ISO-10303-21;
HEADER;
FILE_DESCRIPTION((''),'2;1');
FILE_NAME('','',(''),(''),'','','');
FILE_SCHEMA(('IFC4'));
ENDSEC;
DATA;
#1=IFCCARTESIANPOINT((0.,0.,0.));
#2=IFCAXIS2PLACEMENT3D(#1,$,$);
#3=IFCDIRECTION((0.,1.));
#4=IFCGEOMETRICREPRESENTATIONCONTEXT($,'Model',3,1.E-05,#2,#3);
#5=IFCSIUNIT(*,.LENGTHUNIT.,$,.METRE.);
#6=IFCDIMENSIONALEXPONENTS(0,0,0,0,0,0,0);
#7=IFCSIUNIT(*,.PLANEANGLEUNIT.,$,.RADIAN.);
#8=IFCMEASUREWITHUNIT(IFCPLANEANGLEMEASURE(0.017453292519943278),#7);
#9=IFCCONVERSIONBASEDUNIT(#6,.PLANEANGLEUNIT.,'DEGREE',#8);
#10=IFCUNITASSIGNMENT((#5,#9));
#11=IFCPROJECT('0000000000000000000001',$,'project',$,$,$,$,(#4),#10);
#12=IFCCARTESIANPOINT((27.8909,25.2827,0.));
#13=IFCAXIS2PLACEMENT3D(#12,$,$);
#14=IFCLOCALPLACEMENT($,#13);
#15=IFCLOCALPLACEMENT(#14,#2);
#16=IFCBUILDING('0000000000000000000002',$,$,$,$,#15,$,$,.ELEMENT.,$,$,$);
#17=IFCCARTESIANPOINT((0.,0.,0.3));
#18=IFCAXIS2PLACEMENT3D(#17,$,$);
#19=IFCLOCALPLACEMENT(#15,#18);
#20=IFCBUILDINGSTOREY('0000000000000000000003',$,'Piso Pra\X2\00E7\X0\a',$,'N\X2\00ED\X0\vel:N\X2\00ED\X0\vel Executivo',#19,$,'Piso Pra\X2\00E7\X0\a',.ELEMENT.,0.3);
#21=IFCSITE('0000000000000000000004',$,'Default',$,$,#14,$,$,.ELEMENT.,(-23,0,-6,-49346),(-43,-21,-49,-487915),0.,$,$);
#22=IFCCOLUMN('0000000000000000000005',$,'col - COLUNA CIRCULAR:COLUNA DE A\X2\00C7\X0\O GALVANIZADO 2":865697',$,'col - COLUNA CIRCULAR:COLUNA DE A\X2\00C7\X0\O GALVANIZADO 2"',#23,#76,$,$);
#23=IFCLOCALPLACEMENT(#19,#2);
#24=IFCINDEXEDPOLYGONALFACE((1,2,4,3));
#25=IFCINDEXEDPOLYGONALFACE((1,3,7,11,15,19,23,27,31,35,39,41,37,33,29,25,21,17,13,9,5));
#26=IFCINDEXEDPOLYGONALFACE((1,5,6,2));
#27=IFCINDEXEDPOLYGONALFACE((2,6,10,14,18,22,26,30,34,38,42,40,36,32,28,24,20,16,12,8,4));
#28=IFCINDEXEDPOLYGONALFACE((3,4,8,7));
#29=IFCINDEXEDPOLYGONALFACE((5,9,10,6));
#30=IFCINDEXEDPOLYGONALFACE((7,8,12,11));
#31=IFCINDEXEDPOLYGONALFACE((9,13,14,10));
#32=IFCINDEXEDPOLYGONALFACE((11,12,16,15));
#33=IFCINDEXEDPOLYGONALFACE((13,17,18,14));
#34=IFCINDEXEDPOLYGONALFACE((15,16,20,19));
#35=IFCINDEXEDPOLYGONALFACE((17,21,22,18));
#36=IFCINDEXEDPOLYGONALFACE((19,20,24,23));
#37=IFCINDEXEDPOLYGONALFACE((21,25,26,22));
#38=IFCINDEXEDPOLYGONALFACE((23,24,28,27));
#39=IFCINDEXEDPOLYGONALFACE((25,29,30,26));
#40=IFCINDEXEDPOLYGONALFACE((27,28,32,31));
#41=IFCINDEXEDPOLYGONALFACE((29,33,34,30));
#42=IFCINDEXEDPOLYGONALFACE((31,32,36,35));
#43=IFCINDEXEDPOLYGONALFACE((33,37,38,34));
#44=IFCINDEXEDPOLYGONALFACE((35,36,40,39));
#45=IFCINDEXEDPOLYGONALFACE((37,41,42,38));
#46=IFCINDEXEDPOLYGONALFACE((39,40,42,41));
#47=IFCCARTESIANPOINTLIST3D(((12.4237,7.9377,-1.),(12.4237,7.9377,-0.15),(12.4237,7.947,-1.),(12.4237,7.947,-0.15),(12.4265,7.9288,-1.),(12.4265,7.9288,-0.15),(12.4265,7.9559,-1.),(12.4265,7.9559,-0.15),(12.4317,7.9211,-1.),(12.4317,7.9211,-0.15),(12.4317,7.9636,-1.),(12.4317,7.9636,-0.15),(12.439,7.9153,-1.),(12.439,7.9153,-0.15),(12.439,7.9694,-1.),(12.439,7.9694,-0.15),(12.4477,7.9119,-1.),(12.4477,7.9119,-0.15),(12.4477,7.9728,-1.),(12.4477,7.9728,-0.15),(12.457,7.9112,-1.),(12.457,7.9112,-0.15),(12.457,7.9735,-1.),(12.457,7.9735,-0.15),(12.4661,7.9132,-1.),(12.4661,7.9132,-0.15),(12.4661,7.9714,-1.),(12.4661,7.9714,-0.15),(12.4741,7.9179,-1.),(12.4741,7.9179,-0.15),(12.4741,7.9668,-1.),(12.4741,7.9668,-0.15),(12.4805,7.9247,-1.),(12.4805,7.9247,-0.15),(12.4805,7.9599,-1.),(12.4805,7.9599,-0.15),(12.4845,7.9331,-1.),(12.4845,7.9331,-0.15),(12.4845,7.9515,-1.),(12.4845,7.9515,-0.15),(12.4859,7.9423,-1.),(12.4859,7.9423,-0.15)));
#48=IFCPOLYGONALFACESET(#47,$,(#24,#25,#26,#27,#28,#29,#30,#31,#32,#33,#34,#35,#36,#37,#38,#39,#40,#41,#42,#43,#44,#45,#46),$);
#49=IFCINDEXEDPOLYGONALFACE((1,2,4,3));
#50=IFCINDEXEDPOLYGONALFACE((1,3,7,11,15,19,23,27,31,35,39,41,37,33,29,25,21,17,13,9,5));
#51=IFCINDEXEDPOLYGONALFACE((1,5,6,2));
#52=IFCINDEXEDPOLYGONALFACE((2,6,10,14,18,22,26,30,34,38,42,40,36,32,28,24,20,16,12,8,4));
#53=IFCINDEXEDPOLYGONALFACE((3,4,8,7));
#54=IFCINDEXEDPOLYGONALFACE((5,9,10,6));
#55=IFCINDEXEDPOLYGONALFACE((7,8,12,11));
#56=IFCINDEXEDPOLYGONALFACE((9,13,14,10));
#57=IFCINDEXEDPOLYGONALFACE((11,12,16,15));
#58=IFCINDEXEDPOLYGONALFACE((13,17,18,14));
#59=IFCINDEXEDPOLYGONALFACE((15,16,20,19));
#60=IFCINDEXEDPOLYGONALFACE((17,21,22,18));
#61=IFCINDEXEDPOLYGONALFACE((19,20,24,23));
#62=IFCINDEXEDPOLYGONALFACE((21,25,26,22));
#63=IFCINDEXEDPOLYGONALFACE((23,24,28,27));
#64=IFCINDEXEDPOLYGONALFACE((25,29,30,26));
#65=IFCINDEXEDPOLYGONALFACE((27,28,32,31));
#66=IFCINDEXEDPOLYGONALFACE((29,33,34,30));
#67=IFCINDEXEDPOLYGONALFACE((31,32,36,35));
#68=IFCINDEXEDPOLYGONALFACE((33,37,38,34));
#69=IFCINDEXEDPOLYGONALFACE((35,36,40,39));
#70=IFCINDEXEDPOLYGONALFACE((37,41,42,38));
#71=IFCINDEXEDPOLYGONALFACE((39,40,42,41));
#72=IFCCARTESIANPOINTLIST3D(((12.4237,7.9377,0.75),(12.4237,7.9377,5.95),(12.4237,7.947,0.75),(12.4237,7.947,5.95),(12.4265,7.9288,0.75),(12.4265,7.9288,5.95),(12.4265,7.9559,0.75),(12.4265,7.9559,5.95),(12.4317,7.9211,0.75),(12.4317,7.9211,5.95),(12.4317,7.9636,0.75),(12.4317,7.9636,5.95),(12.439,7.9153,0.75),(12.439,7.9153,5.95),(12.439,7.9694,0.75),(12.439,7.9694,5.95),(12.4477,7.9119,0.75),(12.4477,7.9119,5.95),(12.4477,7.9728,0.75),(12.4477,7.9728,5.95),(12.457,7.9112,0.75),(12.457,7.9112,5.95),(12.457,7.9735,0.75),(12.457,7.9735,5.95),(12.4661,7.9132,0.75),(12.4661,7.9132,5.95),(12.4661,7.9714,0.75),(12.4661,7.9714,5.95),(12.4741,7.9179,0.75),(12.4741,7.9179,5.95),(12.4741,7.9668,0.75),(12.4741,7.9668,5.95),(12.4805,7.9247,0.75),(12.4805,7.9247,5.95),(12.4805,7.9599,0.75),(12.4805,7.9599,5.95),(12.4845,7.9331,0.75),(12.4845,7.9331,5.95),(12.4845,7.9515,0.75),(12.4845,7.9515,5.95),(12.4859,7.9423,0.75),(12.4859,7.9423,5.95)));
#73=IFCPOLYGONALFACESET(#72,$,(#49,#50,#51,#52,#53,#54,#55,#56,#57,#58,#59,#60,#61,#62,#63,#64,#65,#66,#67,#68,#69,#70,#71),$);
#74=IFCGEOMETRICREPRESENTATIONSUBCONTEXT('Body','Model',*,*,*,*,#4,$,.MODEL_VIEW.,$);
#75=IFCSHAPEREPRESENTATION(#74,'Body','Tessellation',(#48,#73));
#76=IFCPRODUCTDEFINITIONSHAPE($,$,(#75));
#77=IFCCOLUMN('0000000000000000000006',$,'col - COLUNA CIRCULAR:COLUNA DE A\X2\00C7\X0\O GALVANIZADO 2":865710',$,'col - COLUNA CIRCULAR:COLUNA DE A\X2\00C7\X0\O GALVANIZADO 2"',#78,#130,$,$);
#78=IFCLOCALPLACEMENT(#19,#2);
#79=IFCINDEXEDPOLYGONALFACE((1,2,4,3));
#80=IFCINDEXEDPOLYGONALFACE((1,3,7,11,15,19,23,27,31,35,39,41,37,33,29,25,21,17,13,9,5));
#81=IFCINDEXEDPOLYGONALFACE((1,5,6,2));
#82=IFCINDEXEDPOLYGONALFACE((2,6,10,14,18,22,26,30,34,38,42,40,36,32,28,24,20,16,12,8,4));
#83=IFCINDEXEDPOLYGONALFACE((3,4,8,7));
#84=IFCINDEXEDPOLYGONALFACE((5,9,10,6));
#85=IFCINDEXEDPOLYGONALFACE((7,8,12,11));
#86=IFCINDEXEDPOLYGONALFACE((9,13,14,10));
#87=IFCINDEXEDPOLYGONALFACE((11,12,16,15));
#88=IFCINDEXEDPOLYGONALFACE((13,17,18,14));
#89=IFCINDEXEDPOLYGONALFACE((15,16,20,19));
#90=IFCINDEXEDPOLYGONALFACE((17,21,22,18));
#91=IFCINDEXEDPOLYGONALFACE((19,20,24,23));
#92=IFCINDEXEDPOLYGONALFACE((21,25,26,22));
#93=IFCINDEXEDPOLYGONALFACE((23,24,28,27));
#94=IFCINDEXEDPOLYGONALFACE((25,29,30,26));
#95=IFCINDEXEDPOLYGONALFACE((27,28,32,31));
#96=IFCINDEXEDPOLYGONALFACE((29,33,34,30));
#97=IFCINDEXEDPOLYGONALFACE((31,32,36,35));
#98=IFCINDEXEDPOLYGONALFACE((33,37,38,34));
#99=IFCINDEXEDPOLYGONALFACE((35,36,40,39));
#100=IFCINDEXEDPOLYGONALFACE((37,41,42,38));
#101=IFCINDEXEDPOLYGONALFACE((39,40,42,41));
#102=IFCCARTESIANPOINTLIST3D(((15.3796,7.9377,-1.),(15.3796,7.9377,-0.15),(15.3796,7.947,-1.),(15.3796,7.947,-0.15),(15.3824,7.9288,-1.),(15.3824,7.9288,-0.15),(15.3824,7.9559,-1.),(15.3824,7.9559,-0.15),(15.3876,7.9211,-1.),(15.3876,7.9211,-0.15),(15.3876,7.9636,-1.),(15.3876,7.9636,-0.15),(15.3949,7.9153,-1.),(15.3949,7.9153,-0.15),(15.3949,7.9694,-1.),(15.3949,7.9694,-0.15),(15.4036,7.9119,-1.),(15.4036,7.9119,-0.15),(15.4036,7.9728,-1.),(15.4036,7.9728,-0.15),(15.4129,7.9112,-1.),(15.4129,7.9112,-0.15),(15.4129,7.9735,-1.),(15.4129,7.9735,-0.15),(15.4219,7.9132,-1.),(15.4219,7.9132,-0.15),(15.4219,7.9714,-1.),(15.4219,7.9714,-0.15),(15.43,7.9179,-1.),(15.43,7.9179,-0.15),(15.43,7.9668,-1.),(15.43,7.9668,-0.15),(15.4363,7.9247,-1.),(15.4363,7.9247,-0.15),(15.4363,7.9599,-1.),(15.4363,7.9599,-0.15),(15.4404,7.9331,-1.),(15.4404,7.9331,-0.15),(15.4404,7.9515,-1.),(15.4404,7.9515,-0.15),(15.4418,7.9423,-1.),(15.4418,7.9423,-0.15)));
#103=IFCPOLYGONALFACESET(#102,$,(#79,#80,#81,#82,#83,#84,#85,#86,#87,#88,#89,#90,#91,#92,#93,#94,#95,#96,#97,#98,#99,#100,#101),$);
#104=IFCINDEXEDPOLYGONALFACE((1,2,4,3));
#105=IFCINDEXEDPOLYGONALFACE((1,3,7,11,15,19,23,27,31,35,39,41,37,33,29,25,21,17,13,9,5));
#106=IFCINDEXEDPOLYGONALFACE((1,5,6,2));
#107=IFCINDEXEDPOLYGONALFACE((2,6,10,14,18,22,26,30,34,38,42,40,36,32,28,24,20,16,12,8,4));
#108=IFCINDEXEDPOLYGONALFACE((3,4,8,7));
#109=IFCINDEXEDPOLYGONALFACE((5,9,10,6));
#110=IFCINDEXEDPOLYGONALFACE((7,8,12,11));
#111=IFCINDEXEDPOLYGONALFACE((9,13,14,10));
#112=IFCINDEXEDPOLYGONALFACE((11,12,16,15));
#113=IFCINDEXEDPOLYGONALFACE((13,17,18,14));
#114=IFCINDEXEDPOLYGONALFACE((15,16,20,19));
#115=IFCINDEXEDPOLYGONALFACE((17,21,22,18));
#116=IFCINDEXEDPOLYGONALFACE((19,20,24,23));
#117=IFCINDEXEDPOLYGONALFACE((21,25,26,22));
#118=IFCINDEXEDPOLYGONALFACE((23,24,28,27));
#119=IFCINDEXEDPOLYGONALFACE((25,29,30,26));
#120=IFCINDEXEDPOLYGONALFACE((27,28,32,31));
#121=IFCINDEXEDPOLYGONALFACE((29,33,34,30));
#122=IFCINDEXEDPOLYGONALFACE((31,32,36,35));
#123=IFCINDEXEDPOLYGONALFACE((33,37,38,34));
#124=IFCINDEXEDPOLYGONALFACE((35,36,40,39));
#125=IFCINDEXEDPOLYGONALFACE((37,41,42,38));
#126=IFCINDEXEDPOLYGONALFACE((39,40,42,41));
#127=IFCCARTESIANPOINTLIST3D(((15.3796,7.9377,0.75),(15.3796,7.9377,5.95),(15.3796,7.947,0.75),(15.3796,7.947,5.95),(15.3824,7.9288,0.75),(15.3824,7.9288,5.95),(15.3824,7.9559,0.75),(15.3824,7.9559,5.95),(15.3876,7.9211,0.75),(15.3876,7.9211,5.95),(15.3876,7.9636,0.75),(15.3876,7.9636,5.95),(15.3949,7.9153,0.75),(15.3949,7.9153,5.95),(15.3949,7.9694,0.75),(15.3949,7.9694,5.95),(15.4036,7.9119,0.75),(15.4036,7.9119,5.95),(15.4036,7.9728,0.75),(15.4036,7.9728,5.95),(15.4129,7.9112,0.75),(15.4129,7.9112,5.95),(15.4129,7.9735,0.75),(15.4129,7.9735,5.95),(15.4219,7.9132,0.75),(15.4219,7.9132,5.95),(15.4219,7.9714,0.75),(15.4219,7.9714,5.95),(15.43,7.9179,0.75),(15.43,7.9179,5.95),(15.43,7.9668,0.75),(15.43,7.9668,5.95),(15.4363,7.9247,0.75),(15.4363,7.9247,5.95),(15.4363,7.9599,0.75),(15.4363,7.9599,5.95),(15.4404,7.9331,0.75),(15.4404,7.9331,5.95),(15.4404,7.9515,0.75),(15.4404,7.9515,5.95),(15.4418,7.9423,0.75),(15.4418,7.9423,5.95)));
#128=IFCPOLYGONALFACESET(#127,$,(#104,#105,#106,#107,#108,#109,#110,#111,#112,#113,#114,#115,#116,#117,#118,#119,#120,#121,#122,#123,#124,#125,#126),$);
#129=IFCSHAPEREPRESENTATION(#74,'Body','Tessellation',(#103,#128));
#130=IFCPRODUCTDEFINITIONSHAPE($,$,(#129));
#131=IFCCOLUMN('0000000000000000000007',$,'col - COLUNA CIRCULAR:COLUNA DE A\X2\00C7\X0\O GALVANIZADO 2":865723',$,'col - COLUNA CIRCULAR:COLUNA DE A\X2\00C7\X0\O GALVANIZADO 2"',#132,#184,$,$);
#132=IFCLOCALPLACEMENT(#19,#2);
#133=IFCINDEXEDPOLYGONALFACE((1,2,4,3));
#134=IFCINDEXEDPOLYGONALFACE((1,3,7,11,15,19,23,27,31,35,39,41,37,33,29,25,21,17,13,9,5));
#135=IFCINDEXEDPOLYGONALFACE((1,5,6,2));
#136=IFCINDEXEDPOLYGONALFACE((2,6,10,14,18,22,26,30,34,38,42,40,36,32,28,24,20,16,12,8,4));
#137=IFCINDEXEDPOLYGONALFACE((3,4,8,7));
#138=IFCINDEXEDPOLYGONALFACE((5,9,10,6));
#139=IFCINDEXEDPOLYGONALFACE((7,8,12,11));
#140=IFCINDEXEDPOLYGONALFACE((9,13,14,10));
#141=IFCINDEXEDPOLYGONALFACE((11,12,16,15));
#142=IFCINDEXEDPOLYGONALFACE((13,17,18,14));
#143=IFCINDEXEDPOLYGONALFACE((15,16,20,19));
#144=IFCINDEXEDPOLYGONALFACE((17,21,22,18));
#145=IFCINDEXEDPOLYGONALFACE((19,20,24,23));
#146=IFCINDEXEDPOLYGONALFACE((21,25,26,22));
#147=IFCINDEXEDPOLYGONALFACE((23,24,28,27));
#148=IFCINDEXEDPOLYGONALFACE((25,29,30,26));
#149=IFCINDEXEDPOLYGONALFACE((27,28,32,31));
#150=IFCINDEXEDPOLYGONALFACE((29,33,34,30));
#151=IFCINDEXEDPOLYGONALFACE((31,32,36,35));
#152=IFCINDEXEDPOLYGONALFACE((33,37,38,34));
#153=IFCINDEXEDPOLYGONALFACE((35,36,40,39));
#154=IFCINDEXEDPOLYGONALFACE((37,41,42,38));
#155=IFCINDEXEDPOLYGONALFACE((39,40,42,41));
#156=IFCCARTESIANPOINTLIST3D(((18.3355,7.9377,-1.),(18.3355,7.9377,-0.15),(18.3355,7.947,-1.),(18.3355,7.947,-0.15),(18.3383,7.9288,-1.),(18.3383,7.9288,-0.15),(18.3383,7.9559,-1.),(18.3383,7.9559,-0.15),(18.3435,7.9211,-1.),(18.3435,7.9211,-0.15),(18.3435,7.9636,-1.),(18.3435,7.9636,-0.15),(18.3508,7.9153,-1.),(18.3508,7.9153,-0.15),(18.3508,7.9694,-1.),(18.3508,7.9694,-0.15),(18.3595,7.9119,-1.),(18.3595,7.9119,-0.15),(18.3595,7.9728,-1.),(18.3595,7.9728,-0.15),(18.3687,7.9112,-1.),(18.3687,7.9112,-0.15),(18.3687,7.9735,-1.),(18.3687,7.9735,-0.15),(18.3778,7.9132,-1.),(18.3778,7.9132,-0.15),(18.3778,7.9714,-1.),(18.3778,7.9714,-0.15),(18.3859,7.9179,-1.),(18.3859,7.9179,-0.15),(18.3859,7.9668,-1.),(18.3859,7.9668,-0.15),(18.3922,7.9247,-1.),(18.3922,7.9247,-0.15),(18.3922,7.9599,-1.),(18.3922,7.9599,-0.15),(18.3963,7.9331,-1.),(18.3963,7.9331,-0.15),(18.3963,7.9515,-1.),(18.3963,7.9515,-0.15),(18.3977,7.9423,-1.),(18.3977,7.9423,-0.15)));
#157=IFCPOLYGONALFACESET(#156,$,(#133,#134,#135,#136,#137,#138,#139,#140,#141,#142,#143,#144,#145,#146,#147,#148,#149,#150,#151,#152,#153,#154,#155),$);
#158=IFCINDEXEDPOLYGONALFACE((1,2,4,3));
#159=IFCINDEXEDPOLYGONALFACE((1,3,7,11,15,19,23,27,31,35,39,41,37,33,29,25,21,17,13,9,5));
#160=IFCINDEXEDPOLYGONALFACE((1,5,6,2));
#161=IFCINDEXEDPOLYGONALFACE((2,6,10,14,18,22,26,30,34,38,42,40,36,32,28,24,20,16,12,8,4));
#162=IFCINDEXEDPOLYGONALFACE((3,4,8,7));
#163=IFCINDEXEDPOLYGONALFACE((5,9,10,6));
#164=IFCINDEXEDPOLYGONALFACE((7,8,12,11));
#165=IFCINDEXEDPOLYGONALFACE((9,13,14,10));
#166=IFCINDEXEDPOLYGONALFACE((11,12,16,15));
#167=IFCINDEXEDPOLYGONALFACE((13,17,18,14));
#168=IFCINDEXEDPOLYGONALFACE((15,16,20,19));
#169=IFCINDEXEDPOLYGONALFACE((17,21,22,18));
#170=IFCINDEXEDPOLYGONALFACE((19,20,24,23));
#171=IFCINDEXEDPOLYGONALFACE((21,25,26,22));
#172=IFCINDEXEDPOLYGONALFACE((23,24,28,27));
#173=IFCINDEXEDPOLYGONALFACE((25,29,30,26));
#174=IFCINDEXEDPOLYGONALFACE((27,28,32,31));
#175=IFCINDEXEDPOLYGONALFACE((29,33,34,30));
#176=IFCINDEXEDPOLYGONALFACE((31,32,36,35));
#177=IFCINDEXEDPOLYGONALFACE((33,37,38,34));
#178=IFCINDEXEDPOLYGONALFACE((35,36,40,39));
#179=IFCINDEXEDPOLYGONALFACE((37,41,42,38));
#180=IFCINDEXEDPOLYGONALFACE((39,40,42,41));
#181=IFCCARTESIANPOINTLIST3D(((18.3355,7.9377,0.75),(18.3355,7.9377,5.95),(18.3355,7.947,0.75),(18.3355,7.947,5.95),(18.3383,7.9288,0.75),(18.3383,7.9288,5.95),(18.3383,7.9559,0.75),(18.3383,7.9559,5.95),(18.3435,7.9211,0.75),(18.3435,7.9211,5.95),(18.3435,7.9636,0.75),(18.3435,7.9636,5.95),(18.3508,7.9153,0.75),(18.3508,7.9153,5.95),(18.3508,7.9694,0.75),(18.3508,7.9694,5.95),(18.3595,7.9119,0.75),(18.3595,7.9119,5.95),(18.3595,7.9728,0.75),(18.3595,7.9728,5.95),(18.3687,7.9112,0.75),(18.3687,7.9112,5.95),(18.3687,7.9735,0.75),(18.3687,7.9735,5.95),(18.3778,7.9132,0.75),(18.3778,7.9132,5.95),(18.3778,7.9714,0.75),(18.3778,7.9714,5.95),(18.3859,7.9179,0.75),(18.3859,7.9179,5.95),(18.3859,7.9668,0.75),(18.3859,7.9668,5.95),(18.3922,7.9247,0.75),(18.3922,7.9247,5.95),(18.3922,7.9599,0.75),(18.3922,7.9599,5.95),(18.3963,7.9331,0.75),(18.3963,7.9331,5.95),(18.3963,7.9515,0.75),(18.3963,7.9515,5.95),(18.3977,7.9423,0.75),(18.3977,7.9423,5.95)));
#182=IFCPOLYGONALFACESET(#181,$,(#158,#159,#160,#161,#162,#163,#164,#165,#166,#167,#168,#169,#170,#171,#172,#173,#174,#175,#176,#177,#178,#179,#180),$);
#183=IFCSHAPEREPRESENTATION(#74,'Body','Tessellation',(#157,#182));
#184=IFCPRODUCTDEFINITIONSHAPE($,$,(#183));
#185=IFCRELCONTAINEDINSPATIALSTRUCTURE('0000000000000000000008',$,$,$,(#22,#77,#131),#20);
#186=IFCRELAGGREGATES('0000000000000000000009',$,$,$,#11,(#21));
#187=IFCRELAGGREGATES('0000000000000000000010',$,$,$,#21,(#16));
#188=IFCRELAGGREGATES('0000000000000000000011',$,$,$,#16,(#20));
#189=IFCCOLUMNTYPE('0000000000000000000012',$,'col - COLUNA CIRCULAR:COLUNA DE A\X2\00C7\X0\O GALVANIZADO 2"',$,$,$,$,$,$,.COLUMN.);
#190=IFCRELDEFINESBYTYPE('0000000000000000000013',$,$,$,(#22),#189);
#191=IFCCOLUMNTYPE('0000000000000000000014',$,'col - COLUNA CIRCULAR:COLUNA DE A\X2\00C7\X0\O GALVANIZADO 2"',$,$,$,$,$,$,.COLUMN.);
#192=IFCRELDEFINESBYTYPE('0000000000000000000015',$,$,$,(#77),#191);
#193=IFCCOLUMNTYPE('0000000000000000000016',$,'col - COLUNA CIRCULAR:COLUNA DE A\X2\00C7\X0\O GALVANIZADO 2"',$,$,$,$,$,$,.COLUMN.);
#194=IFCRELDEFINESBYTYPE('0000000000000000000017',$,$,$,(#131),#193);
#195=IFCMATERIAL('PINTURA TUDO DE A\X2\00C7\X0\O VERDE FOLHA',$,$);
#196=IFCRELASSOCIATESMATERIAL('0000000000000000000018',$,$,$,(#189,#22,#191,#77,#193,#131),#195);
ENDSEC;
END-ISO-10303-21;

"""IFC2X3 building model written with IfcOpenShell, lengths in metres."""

from ifc_helpers import new_model, entity, si_unit, converted_unit, direction, frame, origin, origin_2d_with_axis, place, context, subcontext, project, spatial, circle, extrude, source, transform, mapped, material, type_object, type_shapes, element, save


model = new_model("IFC2X3")

# Units and contexts
model_context = context("Model", 3, precision=1e-05, world=origin(), true_north=direction((0.0, 1.0)))
body_context = subcontext(model_context, "Body", "Model", "MODEL_VIEW")
ifc_project = project(units=[si_unit("LENGTHUNIT", "METRE"), converted_unit("PLANEANGLEUNIT", "DEGREE", entity("IfcPlaneAngleMeasure", 0.017453292519943278), si_unit("PLANEANGLEUNIT", "RADIAN"), dimensions=[0, 0, 0, 0, 0, 0, 0])], contexts=[model_context])

# Site, building, storey
site_placement = place(None, frame((27.8909, 25.2827, 0.0)))
site = spatial("IfcSite", under=ifc_project, at=site_placement, Name="Default", CompositionType="ELEMENT", RefLatitude=(-23, 0, -6, -49346), RefLongitude=(-43, -21, -49, -487915), RefElevation=0.0)
building_placement = place(site_placement, origin())
building = spatial("IfcBuilding", under=site, at=building_placement, CompositionType="ELEMENT")
storey_placement = place(building_placement, frame((0.0, 0.0, 0.3)))
storey = spatial("IfcBuildingStorey", under=building, at=storey_placement, Name="Piso Praça", ObjectType="Nível:Nível Executivo", LongName="Piso Praça", CompositionType="ELEMENT", Elevation=0.3)

# Columns
ifc_material_1 = material(Name="PINTURA TUDO DE AÇO VERDE FOLHA")
column_type_1 = type_object("IfcColumnType", Name="col - COLUNA CIRCULAR:COLUNA DE AÇO GALVANIZADO 2\"", PredefinedType="COLUMN", material=ifc_material_1)
shared_shape_1 = source(origin(), body_context, "Body", "SweptSolid", [
    extrude(circle(Radius=0.0312, at=origin_2d_with_axis()), frame((12.4546, 7.9423, -0.7)), (0.0, 0.0, 1.0), 0.85),
    extrude(circle(Radius=0.0312, at=origin_2d_with_axis()), frame((12.4546, 7.9423, 1.05)), (0.0, 0.0, 1.0), 5.2),
])
type_shapes(column_type_1, [shared_shape_1])
column_1_placement = place(storey_placement, frame((0.0, 0.0, -0.3)))
element("IfcColumn", 1, at=column_1_placement, inside=storey, type_object=column_type_1, material=ifc_material_1, Name="col - COLUNA CIRCULAR:COLUNA DE AÇO GALVANIZADO 2\":865697", ObjectType="col - COLUNA CIRCULAR:COLUNA DE AÇO GALVANIZADO 2\"", context=body_context, shape_type="MappedRepresentation", body=[
    mapped(shared_shape_1, transform((0.0, 0.0, 0.0), scale=1.0)),
])
column_type_2 = type_object("IfcColumnType", Name="col - COLUNA CIRCULAR:COLUNA DE AÇO GALVANIZADO 2\"", PredefinedType="COLUMN", material=ifc_material_1)
shared_shape_2 = source(origin(), body_context, "Body", "SweptSolid", [
    extrude(circle(Radius=0.0312, at=origin_2d_with_axis()), frame((15.4105, 7.9423, -0.7)), (0.0, 0.0, 1.0), 0.85),
    extrude(circle(Radius=0.0312, at=origin_2d_with_axis()), frame((15.4105, 7.9423, 1.05)), (0.0, 0.0, 1.0), 5.2),
])
type_shapes(column_type_2, [shared_shape_2])
column_2_placement = place(storey_placement, frame((0.0, 0.0, -0.3)))
element("IfcColumn", 2, at=column_2_placement, inside=storey, type_object=column_type_2, material=ifc_material_1, Name="col - COLUNA CIRCULAR:COLUNA DE AÇO GALVANIZADO 2\":865710", ObjectType="col - COLUNA CIRCULAR:COLUNA DE AÇO GALVANIZADO 2\"", context=body_context, shape_type="MappedRepresentation", body=[
    mapped(shared_shape_2, transform((0.0, 0.0, 0.0), scale=1.0)),
])
column_type_3 = type_object("IfcColumnType", Name="col - COLUNA CIRCULAR:COLUNA DE AÇO GALVANIZADO 2\"", PredefinedType="COLUMN", material=ifc_material_1)
shared_shape_3 = source(origin(), body_context, "Body", "SweptSolid", [
    extrude(circle(Radius=0.0312, at=origin_2d_with_axis()), frame((18.3664, 7.9423, -0.7)), (0.0, 0.0, 1.0), 0.85),
    extrude(circle(Radius=0.0312, at=origin_2d_with_axis()), frame((18.3664, 7.9423, 1.05)), (0.0, 0.0, 1.0), 5.2),
])
type_shapes(column_type_3, [shared_shape_3])
column_3_placement = place(storey_placement, frame((0.0, 0.0, -0.3)))
element("IfcColumn", 3, at=column_3_placement, inside=storey, type_object=column_type_3, material=ifc_material_1, Name="col - COLUNA CIRCULAR:COLUNA DE AÇO GALVANIZADO 2\":865723", ObjectType="col - COLUNA CIRCULAR:COLUNA DE AÇO GALVANIZADO 2\"", context=body_context, shape_type="MappedRepresentation", body=[
    mapped(shared_shape_3, transform((0.0, 0.0, 0.0), scale=1.0)),
])

save(model, "model.ifc")
